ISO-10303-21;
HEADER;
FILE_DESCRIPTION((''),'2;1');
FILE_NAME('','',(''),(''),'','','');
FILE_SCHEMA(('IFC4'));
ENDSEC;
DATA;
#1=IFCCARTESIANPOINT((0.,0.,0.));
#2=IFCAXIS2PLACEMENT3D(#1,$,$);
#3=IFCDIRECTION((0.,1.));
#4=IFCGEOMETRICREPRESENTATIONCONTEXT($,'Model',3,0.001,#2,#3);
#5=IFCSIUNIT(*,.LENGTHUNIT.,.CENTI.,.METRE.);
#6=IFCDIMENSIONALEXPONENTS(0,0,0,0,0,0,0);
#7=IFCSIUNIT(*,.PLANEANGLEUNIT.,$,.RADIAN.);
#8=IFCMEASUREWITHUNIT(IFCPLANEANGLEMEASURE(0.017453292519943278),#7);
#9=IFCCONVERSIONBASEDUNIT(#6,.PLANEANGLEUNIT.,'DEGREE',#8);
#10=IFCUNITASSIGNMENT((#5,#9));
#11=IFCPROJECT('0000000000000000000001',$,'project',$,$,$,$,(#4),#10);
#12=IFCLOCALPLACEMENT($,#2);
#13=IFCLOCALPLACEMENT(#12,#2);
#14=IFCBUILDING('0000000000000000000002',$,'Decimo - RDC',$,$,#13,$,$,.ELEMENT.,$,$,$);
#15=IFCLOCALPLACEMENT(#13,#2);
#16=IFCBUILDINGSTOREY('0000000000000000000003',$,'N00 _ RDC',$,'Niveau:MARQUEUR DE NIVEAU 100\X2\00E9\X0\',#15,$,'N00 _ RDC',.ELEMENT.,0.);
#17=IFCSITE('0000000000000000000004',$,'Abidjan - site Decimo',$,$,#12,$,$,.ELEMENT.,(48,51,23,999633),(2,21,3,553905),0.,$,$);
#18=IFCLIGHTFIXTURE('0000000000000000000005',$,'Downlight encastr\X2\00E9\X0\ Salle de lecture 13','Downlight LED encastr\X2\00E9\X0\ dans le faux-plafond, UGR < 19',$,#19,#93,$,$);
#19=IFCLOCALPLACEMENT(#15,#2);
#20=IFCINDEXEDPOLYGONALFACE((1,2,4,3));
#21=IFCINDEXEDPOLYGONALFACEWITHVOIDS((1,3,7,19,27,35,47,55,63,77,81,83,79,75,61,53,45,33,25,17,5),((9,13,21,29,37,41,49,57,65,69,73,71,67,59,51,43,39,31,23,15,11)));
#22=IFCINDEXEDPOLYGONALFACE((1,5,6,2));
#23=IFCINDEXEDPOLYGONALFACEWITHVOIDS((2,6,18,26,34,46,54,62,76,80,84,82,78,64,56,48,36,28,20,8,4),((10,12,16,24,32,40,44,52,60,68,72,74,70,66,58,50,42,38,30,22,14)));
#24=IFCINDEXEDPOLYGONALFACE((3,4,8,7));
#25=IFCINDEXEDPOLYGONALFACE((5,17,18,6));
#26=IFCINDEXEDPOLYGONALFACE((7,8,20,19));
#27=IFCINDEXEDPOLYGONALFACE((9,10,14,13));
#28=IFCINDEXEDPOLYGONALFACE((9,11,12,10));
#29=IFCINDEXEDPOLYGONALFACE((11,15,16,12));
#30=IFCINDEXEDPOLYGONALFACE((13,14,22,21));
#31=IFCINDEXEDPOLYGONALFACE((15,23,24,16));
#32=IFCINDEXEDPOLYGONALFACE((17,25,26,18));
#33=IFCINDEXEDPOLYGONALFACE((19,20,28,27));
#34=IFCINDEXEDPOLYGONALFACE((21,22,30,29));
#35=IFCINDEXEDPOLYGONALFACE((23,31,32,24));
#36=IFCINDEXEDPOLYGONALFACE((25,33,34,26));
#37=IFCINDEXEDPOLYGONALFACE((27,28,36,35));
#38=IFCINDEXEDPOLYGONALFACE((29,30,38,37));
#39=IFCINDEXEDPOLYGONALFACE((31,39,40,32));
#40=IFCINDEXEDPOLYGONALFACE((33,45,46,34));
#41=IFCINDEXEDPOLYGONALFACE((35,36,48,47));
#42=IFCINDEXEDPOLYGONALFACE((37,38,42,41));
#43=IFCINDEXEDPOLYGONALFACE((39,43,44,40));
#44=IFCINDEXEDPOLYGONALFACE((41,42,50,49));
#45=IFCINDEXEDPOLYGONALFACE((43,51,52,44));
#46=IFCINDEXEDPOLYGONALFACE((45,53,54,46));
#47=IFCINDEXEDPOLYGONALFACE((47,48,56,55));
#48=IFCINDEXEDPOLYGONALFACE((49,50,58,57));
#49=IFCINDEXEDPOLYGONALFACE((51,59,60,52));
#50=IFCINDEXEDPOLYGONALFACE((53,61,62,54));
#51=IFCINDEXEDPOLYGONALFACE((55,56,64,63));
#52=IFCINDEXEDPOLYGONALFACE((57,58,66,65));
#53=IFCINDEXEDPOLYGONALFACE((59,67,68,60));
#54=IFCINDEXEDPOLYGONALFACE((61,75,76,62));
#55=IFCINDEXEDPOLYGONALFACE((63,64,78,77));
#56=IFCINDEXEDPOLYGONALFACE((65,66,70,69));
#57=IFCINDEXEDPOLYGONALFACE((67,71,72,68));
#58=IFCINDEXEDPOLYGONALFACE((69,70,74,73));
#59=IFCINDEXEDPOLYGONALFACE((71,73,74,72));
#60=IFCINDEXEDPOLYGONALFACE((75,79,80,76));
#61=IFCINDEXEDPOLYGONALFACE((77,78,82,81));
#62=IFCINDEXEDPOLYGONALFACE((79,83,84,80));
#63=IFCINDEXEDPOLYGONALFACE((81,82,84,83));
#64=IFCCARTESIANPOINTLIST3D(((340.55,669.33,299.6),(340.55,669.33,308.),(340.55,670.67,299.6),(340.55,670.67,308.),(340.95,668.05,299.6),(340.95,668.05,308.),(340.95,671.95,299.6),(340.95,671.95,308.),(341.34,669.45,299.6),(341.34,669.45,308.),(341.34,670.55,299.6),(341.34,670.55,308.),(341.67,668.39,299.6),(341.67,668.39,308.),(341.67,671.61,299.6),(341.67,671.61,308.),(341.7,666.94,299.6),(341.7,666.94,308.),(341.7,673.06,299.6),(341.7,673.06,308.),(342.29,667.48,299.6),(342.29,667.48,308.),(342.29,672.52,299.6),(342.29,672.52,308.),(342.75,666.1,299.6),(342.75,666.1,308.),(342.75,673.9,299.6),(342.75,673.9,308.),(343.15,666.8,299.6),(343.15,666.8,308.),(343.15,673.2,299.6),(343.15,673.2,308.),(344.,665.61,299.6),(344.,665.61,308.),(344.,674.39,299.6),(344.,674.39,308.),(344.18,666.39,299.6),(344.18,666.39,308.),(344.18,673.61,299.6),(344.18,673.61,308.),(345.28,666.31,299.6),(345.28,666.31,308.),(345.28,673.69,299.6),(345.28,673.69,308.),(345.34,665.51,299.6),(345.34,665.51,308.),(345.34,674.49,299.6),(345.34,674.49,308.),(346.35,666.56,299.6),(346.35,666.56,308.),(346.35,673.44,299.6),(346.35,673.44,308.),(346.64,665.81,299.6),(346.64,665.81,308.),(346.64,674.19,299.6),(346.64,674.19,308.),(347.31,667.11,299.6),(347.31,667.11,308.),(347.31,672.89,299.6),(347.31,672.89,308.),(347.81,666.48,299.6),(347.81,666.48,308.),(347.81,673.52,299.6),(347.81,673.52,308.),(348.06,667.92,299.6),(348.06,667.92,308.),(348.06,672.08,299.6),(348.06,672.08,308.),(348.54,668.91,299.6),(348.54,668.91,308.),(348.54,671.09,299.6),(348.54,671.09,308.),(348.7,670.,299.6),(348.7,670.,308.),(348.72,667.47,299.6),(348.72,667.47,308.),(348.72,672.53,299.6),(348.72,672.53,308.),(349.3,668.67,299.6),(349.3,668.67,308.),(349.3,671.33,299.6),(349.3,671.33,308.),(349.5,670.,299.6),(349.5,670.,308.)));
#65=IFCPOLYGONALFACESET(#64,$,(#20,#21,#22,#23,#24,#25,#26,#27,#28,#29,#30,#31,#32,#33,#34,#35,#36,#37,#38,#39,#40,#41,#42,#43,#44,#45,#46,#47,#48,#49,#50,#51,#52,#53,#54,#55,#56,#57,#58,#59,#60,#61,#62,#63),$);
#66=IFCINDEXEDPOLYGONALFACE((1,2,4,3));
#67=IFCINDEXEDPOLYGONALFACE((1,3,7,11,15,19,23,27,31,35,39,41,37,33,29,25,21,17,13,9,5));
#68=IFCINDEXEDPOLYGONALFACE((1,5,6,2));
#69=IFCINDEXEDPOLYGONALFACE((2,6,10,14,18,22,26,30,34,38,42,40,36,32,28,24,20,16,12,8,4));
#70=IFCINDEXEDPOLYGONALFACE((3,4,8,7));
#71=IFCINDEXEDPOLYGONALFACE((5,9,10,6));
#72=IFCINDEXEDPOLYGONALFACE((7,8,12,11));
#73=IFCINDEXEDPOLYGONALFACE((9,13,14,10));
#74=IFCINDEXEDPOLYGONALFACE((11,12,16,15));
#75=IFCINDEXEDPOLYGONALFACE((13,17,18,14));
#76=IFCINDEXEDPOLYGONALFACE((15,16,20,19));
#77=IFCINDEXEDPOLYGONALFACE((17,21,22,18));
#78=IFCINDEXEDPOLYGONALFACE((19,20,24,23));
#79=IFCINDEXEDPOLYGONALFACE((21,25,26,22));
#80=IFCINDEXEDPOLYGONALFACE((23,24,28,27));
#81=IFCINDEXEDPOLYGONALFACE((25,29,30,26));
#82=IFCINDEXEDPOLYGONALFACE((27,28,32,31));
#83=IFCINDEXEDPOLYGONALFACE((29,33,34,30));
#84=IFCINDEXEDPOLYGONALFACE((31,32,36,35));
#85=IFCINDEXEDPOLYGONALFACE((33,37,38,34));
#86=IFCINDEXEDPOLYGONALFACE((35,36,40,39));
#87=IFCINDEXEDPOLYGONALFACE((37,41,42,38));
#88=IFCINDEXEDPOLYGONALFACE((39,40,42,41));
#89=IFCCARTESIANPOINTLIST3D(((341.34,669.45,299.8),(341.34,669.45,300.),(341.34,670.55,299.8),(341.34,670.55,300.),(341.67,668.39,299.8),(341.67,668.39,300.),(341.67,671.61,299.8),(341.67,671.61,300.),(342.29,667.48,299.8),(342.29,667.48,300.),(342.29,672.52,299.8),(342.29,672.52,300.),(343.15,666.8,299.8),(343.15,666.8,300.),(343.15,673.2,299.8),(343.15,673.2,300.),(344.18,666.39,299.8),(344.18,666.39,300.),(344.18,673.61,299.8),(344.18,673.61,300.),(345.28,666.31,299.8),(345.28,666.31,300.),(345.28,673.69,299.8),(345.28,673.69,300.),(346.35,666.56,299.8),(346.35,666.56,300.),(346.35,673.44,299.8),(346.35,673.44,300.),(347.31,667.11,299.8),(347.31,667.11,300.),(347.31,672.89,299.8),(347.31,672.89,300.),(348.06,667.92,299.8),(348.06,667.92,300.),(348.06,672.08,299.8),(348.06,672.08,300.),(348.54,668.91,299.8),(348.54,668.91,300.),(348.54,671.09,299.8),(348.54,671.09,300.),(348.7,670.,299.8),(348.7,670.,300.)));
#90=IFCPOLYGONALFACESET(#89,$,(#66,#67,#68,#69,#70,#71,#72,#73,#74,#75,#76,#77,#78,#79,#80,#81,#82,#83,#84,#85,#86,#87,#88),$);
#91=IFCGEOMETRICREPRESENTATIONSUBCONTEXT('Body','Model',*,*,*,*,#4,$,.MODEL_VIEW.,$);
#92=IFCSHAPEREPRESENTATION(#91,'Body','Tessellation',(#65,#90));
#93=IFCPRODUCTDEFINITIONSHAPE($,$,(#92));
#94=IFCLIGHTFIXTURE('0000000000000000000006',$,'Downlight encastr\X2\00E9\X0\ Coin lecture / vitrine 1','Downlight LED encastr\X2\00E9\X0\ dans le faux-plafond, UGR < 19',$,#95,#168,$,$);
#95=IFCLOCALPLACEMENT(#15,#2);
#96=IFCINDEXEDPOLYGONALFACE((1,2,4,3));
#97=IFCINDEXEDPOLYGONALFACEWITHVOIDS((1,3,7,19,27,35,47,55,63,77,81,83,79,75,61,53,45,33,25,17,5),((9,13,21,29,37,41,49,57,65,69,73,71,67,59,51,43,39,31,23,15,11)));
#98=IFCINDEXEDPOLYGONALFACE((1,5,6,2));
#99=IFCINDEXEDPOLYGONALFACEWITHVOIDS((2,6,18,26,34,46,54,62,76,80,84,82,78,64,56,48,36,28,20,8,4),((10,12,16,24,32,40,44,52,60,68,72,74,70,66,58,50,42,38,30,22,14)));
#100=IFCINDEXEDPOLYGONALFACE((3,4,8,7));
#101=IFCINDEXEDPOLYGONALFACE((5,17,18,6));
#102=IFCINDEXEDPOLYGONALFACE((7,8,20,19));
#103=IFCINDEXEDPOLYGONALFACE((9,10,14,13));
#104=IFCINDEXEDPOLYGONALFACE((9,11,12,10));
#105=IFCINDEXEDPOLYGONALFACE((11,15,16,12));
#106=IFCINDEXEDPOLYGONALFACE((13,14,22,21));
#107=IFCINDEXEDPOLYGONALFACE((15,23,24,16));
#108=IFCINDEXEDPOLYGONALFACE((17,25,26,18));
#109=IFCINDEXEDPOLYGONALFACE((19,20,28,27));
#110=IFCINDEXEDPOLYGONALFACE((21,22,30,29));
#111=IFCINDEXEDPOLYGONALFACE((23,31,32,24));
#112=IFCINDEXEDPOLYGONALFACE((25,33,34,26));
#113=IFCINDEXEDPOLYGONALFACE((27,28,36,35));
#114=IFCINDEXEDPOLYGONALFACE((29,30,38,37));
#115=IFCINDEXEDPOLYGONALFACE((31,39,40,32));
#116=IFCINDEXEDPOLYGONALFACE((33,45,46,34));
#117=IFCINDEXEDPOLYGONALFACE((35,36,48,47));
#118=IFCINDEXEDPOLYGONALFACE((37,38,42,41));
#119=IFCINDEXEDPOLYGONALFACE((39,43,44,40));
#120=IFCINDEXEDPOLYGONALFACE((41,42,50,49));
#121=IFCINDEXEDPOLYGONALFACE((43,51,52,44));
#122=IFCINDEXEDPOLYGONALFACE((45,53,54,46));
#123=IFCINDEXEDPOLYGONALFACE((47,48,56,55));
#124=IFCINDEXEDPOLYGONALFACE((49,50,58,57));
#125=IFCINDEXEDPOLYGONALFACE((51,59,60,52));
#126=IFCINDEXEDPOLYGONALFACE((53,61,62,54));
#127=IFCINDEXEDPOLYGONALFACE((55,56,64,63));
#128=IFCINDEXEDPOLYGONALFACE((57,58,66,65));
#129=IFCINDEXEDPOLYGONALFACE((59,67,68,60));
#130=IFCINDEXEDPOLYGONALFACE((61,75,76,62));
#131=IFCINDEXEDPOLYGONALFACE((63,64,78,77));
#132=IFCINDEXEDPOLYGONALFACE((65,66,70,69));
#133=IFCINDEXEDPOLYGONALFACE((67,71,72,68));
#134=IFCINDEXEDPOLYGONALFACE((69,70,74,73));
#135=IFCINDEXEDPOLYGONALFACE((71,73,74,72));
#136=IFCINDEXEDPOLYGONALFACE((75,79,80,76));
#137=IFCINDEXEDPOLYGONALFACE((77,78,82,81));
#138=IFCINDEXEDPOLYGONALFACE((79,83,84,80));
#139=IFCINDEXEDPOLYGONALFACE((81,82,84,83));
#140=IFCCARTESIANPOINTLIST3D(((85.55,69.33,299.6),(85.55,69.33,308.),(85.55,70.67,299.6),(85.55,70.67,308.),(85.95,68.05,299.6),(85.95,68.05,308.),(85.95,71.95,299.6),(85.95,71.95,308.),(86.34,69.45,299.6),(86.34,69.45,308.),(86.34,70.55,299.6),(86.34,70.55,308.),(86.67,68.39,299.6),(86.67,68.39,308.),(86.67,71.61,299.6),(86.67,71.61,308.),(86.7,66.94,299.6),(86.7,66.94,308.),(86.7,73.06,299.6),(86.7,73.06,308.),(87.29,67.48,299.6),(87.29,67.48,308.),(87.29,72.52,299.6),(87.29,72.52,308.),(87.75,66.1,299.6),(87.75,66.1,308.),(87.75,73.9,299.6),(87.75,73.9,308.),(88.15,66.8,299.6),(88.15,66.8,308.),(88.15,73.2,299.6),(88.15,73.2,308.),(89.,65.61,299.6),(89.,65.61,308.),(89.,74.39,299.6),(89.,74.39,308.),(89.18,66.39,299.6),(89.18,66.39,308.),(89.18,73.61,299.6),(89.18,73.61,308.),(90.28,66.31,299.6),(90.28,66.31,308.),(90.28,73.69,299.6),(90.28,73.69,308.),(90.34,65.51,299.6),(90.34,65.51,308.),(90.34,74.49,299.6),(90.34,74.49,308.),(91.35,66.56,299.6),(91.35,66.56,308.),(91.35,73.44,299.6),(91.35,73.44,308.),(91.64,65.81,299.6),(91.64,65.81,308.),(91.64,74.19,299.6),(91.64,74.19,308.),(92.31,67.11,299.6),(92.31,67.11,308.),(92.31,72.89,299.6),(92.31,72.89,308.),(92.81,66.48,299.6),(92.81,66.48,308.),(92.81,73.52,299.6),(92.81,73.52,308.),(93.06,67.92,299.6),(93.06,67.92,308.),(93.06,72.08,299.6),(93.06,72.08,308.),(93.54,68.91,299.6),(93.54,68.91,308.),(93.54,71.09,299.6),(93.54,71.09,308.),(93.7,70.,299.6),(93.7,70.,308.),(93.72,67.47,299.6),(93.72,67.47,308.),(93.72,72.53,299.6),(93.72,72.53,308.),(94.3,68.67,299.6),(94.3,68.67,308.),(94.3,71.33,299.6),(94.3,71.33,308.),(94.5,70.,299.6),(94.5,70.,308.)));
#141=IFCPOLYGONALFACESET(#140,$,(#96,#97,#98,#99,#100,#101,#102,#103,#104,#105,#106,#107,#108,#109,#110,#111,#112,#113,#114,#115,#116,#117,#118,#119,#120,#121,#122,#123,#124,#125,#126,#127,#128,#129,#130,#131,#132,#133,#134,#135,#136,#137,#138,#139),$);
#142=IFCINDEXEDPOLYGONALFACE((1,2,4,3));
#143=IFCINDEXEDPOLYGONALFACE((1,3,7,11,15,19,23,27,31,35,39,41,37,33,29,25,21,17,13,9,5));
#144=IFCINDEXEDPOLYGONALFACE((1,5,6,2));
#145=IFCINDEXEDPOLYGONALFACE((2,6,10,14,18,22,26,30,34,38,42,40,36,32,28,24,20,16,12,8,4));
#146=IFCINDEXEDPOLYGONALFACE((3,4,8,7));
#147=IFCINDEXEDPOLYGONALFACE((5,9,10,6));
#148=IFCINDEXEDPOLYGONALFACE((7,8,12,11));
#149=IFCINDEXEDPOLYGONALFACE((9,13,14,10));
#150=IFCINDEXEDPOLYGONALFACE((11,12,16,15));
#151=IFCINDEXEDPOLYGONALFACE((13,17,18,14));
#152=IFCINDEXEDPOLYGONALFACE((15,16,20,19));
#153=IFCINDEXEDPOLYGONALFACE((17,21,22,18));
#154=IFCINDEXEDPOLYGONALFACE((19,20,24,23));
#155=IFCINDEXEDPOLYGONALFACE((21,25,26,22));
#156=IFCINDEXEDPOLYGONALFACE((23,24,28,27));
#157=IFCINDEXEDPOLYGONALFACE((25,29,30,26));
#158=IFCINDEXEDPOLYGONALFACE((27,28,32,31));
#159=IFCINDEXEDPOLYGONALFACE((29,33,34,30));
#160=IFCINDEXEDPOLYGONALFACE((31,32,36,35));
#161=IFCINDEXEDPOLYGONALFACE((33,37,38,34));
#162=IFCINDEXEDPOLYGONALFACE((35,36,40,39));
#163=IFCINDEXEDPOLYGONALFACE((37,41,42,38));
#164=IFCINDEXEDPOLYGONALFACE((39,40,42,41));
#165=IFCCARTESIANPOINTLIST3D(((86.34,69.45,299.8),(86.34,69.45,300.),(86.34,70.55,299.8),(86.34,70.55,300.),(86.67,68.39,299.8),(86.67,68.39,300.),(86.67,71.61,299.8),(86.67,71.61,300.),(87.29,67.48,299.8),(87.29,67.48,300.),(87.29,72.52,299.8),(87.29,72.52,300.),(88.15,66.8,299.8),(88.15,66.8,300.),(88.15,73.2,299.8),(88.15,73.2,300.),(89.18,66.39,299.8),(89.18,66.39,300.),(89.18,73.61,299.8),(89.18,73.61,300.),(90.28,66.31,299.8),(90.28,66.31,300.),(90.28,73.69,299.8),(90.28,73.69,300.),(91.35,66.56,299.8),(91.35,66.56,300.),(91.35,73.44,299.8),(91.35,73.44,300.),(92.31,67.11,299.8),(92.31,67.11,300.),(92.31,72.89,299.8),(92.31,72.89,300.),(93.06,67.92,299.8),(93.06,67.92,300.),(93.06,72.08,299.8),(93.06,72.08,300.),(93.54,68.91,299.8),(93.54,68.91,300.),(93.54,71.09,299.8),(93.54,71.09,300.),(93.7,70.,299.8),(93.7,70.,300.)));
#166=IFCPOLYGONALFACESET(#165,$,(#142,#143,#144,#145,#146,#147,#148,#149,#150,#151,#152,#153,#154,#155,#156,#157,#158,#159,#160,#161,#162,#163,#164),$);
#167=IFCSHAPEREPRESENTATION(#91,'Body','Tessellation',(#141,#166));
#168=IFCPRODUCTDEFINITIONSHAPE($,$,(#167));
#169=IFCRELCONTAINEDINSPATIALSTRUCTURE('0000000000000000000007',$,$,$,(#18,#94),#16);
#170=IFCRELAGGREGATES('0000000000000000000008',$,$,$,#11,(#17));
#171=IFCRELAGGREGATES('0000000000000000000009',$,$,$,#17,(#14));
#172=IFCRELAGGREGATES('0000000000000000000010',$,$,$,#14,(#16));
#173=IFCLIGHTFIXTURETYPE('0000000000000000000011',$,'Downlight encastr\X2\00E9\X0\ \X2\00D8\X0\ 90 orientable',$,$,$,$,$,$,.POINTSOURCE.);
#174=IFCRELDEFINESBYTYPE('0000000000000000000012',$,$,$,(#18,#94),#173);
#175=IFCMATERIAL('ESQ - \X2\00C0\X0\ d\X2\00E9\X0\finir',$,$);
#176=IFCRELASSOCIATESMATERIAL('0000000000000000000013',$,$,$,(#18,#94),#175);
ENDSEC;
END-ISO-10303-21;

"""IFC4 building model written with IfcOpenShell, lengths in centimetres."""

from ifc_helpers import new_model, entity, si_unit, converted_unit, direction, frame, frame_2d, origin, origin_with_axes, place, context, subcontext, project, spatial, circle, hollow_circle, extrude, material, type_object, element, save


model = new_model("IFC4")

# Units and contexts
model_context = context("Model", 3, precision=0.001, world=origin(), true_north=direction((0.0, 1.0)))
body_context = subcontext(model_context, "Body", "Model", "MODEL_VIEW")
ifc_project = project(units=[si_unit("LENGTHUNIT", "METRE", prefix="CENTI"), converted_unit("PLANEANGLEUNIT", "DEGREE", entity("IfcPlaneAngleMeasure", 0.017453292519943278), si_unit("PLANEANGLEUNIT", "RADIAN"), dimensions=[0, 0, 0, 0, 0, 0, 0])], contexts=[model_context])

# Site, building, storey
site_placement = place(None, origin())
site = spatial("IfcSite", under=ifc_project, at=site_placement, Name="Abidjan - site Decimo", CompositionType="ELEMENT", RefLatitude=(48, 51, 23, 999633), RefLongitude=(2, 21, 3, 553905), RefElevation=0.0)
building_placement = place(site_placement, origin())
building = spatial("IfcBuilding", under=site, at=building_placement, Name="Decimo - RDC", CompositionType="ELEMENT")
storey_placement = place(building_placement, origin())
storey = spatial("IfcBuildingStorey", under=building, at=storey_placement, Name="N00 _ RDC", ObjectType="Niveau:MARQUEUR DE NIVEAU 100é", LongName="N00 _ RDC", CompositionType="ELEMENT", Elevation=0.0)

# Light fixtures
ifc_material_1 = material(Name="ESQ - À définir")
light_fixture_type_1 = type_object("IfcLightFixtureType", Name="Downlight encastré Ø 90 orientable", PredefinedType="POINTSOURCE")
light_fixture_1_placement = place(storey_placement, origin_with_axes())
element("IfcLightFixture", 1, at=light_fixture_1_placement, inside=storey, type_object=light_fixture_type_1, material=ifc_material_1, Name="Downlight encastré Salle de lecture 13", Description="Downlight LED encastré dans le faux-plafond, UGR < 19", context=body_context, shape_type="SweptSolid", body=[
    extrude(hollow_circle(Radius=4.5, WallThickness=0.8, at=frame_2d((345.0, 670.0))), frame((0.0, 0.0, 299.6)), (0.0, 0.0, 1.0), 8.4),
    extrude(circle(Radius=3.7, at=frame_2d((345.0, 670.0))), frame((0.0, 0.0, 299.8)), (0.0, 0.0, 1.0), 0.2),
])
light_fixture_2_placement = place(storey_placement, origin_with_axes())
element("IfcLightFixture", 2, at=light_fixture_2_placement, inside=storey, type_object=light_fixture_type_1, material=ifc_material_1, Name="Downlight encastré Coin lecture / vitrine 1", Description="Downlight LED encastré dans le faux-plafond, UGR < 19", context=body_context, shape_type="SweptSolid", body=[
    extrude(hollow_circle(Radius=4.5, WallThickness=0.8, at=frame_2d((90.0, 70.0))), frame((0.0, 0.0, 299.6)), (0.0, 0.0, 1.0), 8.4),
    extrude(circle(Radius=3.7, at=frame_2d((90.0, 70.0))), frame((0.0, 0.0, 299.8)), (0.0, 0.0, 1.0), 0.2),
])

save(model, "model.ifc")
